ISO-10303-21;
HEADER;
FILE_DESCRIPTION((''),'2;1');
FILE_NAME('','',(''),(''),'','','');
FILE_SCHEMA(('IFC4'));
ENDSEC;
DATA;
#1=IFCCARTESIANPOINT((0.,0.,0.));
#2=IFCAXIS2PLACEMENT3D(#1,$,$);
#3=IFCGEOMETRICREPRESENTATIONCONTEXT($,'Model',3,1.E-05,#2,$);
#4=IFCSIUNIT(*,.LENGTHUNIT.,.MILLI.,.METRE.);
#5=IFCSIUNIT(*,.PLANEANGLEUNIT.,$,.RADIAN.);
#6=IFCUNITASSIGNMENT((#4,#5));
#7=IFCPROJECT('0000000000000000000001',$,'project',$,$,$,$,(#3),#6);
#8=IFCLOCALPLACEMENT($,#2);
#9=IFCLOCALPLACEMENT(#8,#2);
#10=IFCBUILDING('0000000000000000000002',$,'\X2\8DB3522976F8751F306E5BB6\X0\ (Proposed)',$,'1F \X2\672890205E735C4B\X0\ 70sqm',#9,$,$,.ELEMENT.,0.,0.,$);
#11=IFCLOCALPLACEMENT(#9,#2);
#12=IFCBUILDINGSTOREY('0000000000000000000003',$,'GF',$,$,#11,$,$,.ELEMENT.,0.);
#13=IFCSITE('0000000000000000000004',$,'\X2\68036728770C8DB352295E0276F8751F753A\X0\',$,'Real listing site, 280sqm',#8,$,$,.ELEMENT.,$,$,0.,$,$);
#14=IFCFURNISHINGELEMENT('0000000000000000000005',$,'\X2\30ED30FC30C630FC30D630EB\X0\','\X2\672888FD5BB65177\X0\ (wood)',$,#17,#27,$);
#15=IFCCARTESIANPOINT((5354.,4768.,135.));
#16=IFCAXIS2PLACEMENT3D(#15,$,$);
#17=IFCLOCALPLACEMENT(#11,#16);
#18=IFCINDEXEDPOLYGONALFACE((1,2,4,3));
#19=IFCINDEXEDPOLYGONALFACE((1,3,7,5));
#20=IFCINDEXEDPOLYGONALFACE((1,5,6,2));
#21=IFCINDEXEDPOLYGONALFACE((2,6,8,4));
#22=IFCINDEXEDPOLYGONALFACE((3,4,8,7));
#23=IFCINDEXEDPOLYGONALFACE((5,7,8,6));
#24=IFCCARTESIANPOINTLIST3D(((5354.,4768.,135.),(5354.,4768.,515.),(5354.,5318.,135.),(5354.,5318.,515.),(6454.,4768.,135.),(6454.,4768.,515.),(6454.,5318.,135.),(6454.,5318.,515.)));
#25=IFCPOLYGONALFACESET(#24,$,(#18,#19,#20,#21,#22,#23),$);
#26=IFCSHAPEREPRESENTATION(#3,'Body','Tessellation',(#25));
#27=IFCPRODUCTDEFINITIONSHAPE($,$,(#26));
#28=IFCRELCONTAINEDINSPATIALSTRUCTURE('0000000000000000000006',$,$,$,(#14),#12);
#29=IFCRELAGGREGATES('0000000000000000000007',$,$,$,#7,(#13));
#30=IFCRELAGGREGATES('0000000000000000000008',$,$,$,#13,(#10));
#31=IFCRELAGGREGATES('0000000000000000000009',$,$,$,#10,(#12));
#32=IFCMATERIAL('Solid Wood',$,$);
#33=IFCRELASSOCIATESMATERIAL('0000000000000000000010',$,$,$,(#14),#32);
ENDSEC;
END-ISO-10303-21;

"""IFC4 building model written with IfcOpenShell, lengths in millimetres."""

from ifc_helpers import new_model, si_unit, frame, frame_2d, origin, place, context, project, spatial, rectangle, extrude, material, element, save


model = new_model("IFC4")

# Units and contexts
model_context = context("Model", 3, precision=1e-05, world=origin())
ifc_project = project(units=[si_unit("LENGTHUNIT", "METRE", prefix="MILLI"), si_unit("PLANEANGLEUNIT", "RADIAN")], contexts=[model_context])

# Site, building, storey
site_placement = place(None, origin())
site = spatial("IfcSite", under=ifc_project, at=site_placement, Name="栃木県足利市相生町", ObjectType="Real listing site, 280sqm", CompositionType="ELEMENT", RefElevation=0.0)
building_placement = place(site_placement, origin())
building = spatial("IfcBuilding", under=site, at=building_placement, Name="足利相生の家 (Proposed)", ObjectType="1F 木造平屋 70sqm", CompositionType="ELEMENT", ElevationOfRefHeight=0.0, ElevationOfTerrain=0.0)
storey_placement = place(building_placement, origin())
storey = spatial("IfcBuildingStorey", under=building, at=storey_placement, Name="GF", CompositionType="ELEMENT", Elevation=0.0)

# Shared definitions
ifc_material_1 = material(Name="Solid Wood")

# Furnishing element
furnishing_1_placement = place(storey_placement, frame((5354.0, 4768.0, 135.0)))
element("IfcFurnishingElement", 1, at=furnishing_1_placement, inside=storey, material=ifc_material_1, Name="ローテーブル", Description="木製家具 (wood)", context=model_context, shape_type="SweptSolid", body=[
    extrude(rectangle(XDim=1100.0, YDim=550.0, at=frame_2d((550.0, 275.0))), frame((5354.0, 4768.0, 135.0)), (0.0, 0.0, 1.0), 380.0),
])

save(model, "model.ifc")
